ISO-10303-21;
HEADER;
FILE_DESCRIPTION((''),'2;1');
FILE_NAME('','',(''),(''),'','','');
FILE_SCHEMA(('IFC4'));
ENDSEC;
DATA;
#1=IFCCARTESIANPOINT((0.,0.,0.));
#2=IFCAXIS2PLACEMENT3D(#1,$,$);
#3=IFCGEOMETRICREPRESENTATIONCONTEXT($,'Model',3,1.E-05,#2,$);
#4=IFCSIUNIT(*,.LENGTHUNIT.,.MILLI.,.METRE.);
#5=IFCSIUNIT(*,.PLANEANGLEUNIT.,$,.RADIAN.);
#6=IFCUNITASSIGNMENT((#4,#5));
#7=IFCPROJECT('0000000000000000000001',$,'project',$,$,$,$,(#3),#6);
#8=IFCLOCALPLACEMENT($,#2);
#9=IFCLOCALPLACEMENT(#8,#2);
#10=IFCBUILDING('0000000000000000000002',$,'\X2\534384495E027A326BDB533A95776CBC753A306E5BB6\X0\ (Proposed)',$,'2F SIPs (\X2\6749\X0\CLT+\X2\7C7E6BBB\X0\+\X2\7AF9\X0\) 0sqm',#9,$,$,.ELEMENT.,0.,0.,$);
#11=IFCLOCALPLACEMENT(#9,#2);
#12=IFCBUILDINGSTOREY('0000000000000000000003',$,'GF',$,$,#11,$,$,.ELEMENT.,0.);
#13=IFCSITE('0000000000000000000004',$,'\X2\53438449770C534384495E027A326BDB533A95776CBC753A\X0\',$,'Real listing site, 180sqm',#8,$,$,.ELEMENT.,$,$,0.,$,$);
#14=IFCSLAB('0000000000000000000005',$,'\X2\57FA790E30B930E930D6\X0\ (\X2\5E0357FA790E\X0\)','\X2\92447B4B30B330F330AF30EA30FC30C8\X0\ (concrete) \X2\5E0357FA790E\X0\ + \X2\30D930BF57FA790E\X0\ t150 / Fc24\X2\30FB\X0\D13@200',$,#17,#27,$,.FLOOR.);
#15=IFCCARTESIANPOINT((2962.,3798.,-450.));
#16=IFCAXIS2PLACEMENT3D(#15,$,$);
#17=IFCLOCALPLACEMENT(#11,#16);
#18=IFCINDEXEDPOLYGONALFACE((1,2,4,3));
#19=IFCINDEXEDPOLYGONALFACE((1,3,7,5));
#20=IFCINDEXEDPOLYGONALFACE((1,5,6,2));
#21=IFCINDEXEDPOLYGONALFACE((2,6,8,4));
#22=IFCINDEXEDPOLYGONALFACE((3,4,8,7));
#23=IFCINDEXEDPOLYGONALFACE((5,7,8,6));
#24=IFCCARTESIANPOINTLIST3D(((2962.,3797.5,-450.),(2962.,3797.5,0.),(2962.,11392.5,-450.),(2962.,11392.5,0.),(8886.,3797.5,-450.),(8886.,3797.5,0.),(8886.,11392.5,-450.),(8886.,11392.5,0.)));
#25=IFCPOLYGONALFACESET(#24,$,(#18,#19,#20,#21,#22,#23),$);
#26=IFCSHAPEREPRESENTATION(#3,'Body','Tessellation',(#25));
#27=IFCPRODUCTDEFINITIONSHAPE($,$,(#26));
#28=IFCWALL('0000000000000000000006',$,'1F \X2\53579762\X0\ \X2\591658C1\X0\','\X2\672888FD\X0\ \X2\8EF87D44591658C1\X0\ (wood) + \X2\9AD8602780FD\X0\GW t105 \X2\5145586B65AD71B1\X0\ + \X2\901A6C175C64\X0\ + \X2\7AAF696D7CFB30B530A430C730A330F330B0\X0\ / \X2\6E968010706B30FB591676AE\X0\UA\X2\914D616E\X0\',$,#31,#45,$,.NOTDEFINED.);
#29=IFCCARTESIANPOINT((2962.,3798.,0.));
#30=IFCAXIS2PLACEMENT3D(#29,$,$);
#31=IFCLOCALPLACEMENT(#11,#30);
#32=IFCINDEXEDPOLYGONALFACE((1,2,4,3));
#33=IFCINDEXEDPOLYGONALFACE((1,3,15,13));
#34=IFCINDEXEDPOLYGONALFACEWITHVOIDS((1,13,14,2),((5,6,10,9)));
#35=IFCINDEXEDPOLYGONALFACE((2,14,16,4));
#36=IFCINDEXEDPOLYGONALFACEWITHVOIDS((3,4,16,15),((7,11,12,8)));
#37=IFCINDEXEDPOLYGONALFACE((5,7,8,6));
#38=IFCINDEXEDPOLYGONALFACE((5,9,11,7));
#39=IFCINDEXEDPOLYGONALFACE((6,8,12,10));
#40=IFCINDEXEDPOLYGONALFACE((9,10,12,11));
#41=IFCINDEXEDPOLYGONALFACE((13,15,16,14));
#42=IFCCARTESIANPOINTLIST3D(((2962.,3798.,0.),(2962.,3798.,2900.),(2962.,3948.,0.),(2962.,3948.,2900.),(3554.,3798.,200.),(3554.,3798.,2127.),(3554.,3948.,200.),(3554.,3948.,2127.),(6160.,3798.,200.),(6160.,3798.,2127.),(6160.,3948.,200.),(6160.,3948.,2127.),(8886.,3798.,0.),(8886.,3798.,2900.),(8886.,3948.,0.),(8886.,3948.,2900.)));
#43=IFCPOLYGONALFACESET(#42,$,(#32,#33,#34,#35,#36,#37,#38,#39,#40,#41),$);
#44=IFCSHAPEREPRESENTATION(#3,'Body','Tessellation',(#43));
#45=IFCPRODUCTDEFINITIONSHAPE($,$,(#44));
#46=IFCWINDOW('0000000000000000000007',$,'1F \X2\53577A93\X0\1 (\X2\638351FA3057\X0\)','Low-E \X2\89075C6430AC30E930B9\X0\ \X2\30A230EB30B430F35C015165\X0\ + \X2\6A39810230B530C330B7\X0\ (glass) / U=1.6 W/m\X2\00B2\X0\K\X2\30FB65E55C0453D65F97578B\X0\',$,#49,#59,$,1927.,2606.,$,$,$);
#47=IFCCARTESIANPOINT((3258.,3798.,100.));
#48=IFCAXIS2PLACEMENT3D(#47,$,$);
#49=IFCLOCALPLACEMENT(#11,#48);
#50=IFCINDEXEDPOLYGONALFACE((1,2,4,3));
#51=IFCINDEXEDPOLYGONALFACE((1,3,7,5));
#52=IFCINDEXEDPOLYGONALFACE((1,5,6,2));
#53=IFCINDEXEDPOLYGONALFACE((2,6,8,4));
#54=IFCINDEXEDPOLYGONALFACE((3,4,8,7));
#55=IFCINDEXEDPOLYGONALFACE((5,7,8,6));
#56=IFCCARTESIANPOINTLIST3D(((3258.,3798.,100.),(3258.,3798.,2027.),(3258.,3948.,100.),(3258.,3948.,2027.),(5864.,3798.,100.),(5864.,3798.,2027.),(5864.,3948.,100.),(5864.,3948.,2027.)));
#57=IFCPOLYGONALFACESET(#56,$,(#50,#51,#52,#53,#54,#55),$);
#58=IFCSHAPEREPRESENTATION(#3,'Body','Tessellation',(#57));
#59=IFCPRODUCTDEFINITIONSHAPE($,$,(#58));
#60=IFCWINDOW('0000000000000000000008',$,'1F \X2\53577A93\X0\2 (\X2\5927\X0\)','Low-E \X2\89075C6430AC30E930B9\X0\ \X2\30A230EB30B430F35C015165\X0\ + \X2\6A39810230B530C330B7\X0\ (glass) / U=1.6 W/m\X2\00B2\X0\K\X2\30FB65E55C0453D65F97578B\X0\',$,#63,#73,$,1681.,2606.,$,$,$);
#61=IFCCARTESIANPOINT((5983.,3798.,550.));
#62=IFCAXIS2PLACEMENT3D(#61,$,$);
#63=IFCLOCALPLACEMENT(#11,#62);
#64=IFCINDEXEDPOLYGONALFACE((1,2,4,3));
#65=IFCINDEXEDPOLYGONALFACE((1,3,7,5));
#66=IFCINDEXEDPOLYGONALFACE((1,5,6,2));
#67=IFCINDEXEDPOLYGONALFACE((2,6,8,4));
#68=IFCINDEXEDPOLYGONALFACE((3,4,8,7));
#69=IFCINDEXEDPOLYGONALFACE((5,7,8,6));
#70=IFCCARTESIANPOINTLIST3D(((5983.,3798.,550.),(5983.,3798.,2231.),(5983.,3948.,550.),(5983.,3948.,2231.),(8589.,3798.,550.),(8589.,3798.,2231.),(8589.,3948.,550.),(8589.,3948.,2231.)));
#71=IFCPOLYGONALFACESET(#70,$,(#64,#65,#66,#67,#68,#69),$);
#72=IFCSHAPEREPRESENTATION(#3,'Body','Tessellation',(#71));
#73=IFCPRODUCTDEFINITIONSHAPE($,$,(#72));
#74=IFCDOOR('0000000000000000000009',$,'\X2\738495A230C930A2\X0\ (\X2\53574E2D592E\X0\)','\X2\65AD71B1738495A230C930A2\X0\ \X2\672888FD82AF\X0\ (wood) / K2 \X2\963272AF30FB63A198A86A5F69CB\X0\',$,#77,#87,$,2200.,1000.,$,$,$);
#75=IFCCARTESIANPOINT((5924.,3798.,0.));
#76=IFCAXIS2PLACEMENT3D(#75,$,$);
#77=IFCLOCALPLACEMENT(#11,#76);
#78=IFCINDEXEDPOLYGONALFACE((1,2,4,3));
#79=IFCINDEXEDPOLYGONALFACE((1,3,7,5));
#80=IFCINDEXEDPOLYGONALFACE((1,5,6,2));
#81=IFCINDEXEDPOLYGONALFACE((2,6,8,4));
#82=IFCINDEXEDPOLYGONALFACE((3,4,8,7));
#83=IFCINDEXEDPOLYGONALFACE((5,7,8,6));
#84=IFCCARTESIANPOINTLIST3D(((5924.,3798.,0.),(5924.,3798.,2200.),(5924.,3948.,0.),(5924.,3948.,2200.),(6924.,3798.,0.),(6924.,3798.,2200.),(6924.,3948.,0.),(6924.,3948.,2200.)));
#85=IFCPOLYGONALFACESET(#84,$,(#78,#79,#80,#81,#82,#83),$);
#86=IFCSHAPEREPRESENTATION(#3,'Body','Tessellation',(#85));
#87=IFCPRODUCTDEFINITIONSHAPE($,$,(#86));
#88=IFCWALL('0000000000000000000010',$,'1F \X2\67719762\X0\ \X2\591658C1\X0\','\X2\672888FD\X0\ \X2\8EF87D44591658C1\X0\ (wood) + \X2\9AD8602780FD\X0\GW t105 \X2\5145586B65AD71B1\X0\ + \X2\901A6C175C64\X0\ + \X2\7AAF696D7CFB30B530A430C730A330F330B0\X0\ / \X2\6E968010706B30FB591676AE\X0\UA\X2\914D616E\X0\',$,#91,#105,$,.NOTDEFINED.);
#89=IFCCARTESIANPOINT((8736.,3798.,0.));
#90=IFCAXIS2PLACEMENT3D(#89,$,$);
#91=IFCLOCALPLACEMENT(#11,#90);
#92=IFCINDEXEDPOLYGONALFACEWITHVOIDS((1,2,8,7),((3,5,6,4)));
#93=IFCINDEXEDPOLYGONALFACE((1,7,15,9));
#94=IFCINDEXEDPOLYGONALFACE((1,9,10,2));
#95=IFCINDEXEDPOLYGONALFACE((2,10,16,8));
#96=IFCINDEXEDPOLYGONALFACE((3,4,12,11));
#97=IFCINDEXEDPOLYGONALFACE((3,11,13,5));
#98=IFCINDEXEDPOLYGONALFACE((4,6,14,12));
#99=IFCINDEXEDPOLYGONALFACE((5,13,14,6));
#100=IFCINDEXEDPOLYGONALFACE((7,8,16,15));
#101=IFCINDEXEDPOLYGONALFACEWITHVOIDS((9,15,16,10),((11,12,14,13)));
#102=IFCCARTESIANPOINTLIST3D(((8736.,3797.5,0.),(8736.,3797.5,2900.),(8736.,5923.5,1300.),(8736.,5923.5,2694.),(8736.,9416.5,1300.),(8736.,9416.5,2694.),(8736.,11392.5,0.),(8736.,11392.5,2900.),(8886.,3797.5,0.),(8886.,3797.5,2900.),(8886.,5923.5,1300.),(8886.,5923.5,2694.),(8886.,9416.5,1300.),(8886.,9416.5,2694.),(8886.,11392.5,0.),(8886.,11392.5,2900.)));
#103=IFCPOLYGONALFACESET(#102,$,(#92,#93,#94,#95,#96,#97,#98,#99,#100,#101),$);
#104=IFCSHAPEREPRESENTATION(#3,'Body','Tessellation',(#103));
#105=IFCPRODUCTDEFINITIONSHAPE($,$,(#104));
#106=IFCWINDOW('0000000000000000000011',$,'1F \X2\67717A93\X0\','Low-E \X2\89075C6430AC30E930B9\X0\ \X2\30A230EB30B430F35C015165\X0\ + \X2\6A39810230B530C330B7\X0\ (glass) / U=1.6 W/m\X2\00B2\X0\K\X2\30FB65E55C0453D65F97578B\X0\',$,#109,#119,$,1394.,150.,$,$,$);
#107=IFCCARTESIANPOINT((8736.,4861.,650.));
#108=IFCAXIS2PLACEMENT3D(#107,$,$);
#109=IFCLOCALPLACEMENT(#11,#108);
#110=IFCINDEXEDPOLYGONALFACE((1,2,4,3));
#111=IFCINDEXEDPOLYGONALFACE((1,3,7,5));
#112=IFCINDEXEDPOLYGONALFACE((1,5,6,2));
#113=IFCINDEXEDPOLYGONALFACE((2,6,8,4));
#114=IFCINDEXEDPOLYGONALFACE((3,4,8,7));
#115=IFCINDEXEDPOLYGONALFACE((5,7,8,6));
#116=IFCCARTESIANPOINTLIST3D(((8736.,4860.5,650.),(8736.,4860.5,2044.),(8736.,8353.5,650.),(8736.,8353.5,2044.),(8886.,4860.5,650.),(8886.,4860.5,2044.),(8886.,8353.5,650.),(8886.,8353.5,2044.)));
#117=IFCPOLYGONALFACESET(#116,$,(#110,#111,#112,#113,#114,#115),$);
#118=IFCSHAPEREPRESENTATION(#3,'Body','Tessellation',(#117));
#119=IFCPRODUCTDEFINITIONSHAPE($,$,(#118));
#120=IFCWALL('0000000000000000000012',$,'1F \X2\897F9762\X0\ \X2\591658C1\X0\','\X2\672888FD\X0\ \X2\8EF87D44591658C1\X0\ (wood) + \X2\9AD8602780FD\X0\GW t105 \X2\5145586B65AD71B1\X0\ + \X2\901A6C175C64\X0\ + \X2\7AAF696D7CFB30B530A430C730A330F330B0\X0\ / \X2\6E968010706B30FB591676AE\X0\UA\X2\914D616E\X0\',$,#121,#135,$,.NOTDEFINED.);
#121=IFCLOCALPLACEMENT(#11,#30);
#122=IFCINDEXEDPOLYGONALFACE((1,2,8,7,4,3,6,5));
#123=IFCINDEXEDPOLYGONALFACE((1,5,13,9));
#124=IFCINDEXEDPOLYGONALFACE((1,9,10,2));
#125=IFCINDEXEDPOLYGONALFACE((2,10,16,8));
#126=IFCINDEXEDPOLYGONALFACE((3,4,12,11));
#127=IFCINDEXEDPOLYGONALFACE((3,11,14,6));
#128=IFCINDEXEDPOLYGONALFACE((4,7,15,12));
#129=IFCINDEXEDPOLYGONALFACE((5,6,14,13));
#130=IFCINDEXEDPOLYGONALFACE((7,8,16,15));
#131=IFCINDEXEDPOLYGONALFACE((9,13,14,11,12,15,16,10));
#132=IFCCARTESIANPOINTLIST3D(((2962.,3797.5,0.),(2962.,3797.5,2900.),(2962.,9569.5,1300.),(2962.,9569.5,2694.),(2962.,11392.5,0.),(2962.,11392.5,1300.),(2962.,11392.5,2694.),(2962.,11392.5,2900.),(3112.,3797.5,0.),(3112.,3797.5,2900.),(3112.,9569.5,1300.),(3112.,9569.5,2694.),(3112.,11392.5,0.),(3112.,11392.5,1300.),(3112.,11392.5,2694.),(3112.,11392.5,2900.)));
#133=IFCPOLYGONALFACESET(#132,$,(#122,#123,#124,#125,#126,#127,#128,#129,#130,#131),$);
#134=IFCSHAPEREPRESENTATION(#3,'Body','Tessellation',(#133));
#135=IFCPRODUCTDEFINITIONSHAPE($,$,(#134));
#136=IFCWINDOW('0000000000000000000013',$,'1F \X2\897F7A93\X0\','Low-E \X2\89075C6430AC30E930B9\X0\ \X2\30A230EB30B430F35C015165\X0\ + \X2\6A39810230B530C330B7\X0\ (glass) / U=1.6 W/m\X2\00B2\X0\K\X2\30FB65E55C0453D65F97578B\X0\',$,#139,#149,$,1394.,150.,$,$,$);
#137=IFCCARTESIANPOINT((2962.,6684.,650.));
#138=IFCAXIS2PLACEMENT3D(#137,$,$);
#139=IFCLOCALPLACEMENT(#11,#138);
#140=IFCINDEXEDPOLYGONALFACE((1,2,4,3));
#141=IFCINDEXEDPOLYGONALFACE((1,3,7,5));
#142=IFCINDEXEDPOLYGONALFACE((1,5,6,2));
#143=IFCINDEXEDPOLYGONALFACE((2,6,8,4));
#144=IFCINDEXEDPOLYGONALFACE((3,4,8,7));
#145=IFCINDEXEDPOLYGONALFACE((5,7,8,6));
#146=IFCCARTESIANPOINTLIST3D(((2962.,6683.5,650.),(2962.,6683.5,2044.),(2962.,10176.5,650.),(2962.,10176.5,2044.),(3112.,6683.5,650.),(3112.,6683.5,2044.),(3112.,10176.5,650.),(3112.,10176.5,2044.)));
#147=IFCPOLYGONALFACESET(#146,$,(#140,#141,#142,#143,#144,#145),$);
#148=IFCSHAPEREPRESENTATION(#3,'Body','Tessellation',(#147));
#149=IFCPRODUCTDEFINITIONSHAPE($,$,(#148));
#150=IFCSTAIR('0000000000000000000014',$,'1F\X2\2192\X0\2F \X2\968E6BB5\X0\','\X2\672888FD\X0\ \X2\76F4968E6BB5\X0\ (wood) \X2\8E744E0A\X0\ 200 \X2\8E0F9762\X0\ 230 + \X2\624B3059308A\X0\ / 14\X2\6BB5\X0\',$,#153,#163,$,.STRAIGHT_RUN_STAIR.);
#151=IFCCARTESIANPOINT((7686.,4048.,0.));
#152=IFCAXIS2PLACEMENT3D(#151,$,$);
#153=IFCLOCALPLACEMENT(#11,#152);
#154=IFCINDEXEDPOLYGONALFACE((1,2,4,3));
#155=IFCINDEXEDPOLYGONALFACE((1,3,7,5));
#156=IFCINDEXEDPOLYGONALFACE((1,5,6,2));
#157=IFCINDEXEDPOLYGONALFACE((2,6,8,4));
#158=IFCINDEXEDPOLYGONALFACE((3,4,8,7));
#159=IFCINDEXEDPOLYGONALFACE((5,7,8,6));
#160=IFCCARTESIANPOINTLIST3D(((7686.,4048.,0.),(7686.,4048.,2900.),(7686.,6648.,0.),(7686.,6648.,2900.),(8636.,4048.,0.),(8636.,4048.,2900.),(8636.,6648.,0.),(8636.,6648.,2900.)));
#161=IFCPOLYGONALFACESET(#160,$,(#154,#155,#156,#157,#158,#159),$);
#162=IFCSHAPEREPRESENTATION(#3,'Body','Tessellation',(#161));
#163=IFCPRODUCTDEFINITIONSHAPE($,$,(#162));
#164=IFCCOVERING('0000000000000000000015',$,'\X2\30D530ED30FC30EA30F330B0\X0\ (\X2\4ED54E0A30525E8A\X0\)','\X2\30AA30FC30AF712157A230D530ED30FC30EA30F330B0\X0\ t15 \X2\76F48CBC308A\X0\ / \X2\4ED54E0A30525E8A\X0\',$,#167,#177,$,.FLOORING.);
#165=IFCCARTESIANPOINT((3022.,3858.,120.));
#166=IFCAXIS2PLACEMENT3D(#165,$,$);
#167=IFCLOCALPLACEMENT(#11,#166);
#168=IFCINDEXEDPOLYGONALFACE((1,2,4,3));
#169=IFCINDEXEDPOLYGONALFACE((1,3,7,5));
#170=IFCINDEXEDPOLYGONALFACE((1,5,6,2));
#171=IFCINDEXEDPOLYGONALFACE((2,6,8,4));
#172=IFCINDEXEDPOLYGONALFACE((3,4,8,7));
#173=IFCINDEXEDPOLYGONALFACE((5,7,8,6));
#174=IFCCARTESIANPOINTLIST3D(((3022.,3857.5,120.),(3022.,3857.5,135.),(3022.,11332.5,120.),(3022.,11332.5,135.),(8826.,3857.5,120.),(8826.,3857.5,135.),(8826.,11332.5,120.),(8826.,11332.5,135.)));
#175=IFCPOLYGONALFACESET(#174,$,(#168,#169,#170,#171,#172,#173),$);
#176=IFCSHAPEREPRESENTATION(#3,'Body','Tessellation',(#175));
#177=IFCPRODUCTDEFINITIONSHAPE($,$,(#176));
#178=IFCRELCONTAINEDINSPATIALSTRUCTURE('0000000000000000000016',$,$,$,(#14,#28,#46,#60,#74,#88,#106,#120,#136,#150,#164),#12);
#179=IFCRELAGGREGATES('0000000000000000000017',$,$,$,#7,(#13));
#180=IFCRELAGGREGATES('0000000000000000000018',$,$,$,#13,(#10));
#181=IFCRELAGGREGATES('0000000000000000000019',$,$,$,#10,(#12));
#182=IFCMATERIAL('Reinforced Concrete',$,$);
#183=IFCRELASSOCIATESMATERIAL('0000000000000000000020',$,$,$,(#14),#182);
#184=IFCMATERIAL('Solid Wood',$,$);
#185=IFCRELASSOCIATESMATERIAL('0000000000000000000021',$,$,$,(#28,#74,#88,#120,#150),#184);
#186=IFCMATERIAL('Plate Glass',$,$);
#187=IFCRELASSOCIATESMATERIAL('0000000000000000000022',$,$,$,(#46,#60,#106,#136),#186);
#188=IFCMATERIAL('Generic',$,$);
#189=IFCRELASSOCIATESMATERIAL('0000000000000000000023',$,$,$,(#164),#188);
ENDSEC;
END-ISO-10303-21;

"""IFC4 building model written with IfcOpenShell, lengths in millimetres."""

from ifc_helpers import new_model, si_unit, frame, frame_2d, origin, place, context, project, spatial, rectangle, extrude, material, element, fill, save


model = new_model("IFC4")

# Units and contexts
model_context = context("Model", 3, precision=1e-05, world=origin())
ifc_project = project(units=[si_unit("LENGTHUNIT", "METRE", prefix="MILLI"), si_unit("PLANEANGLEUNIT", "RADIAN")], contexts=[model_context])

# Site, building, storey
site_placement = place(None, origin())
site = spatial("IfcSite", under=ifc_project, at=site_placement, Name="千葉県千葉市稲毛区長沼町", ObjectType="Real listing site, 180sqm", CompositionType="ELEMENT", RefElevation=0.0)
building_placement = place(site_placement, origin())
building = spatial("IfcBuilding", under=site, at=building_placement, Name="千葉市稲毛区長沼町の家 (Proposed)", ObjectType="2F SIPs (杉CLT+籾殻+竹) 0sqm", CompositionType="ELEMENT", ElevationOfRefHeight=0.0, ElevationOfTerrain=0.0)
storey_placement = place(building_placement, origin())
storey = spatial("IfcBuildingStorey", under=building, at=storey_placement, Name="GF", CompositionType="ELEMENT", Elevation=0.0)

# Slab
ifc_material_1 = material(Name="Reinforced Concrete")
slab_1_placement = place(storey_placement, frame((2962.0, 3798.0, -450.0)))
element("IfcSlab", 1, at=slab_1_placement, inside=storey, material=ifc_material_1, Name="基礎スラブ (布基礎)", Description="鉄筋コンクリート (concrete) 布基礎 + ベタ基礎 t150 / Fc24・D13@200", PredefinedType="FLOOR", context=model_context, shape_type="SweptSolid", body=[
    extrude(rectangle(XDim=5924.0, YDim=7595.0, at=frame_2d((2962.0, 3797.0))), frame((2962.0, 3798.0, -450.0)), (0.0, 0.0, 1.0), 450.0),
])
ifc_material_2 = material(Name="Solid Wood")

# Wall, openings, windows, door
wall_1_placement = place(storey_placement, frame((2962.0, 3798.0, 0.0)))
wall_1 = element("IfcWall", 2, at=wall_1_placement, inside=storey, material=ifc_material_2, Name="1F 南面 外壁", Description="木製 軸組外壁 (wood) + 高性能GW t105 充填断熱 + 通気層 + 窯業系サイディング / 準耐火・外皮UA配慮", PredefinedType="NOTDEFINED", context=model_context, shape_type="SweptSolid", body=[
    extrude(rectangle(XDim=5924.0, YDim=150.0, at=frame_2d((2962.0, 75.0))), frame((2962.0, 3798.0, 0.0)), (0.0, 0.0, 1.0), 2900.0),
])
opening_1_placement = place(storey_placement, frame((3258.0, 3798.0, 100.0)))
opening_1 = element("IfcOpeningElement", 3, at=opening_1_placement, cuts=wall_1, PredefinedType="NOTDEFINED", context=model_context, shape_type="SweptSolid", body=[
    extrude(rectangle(XDim=2606.0, YDim=150.0, at=frame_2d((1303.0, 75.0))), frame((3258.0, 3798.0, 100.0)), (0.0, 0.0, 1.0), 1927.0),
])
opening_2_placement = place(storey_placement, frame((5983.0, 3798.0, 550.0)))
opening_2 = element("IfcOpeningElement", 4, at=opening_2_placement, cuts=wall_1, PredefinedType="NOTDEFINED", context=model_context, shape_type="SweptSolid", body=[
    extrude(rectangle(XDim=2606.0, YDim=150.0, at=frame_2d((1303.0, 75.0))), frame((5983.0, 3798.0, 550.0)), (0.0, 0.0, 1.0), 1681.0),
])
opening_3_placement = place(storey_placement, frame((5924.0, 3798.0, 0.0)))
opening_3 = element("IfcOpeningElement", 5, at=opening_3_placement, cuts=wall_1, PredefinedType="NOTDEFINED", context=model_context, shape_type="SweptSolid", body=[
    extrude(rectangle(XDim=1000.0, YDim=150.0, at=frame_2d((500.0, 75.0))), frame((5924.0, 3798.0, 0.0)), (0.0, 0.0, 1.0), 2200.0),
])
ifc_material_3 = material(Name="Plate Glass")
window_1_placement = place(storey_placement, frame((3258.0, 3798.0, 100.0)))
window_1 = element("IfcWindow", 6, at=window_1_placement, inside=storey, material=ifc_material_3, Name="1F 南窓1 (掃出し)", Description="Low-E 複層ガラス アルゴン封入 + 樹脂サッシ (glass) / U=1.6 W/m²K・日射取得型", OverallHeight=1927.0, OverallWidth=2606.0, context=model_context, shape_type="SweptSolid", body=[
    extrude(rectangle(XDim=2606.0, YDim=150.0, at=frame_2d((1303.0, 75.0))), frame((3258.0, 3798.0, 100.0)), (0.0, 0.0, 1.0), 1927.0),
])
fill(opening_1, window_1)
window_2_placement = place(storey_placement, frame((5983.0, 3798.0, 550.0)))
window_2 = element("IfcWindow", 7, at=window_2_placement, inside=storey, material=ifc_material_3, Name="1F 南窓2 (大)", Description="Low-E 複層ガラス アルゴン封入 + 樹脂サッシ (glass) / U=1.6 W/m²K・日射取得型", OverallHeight=1681.0, OverallWidth=2606.0, context=model_context, shape_type="SweptSolid", body=[
    extrude(rectangle(XDim=2606.0, YDim=150.0, at=frame_2d((1303.0, 75.0))), frame((5983.0, 3798.0, 550.0)), (0.0, 0.0, 1.0), 1681.0),
])
fill(opening_2, window_2)
door_placement = place(storey_placement, frame((5924.0, 3798.0, 0.0)))
door = element("IfcDoor", 8, at=door_placement, inside=storey, material=ifc_material_2, Name="玄関ドア (南中央)", Description="断熱玄関ドア 木製芯 (wood) / K2 防犯・採風機構", OverallHeight=2200.0, OverallWidth=1000.0, context=model_context, shape_type="SweptSolid", body=[
    extrude(rectangle(XDim=1000.0, YDim=150.0, at=frame_2d((500.0, 75.0))), frame((5924.0, 3798.0, 0.0)), (0.0, 0.0, 1.0), 2200.0),
])
fill(opening_3, door)

# Walls, openings, windows
wall_2_placement = place(storey_placement, frame((8736.0, 3798.0, 0.0)))
wall_2 = element("IfcWall", 9, at=wall_2_placement, inside=storey, material=ifc_material_2, Name="1F 東面 外壁", Description="木製 軸組外壁 (wood) + 高性能GW t105 充填断熱 + 通気層 + 窯業系サイディング / 準耐火・外皮UA配慮", PredefinedType="NOTDEFINED", context=model_context, shape_type="SweptSolid", body=[
    extrude(rectangle(XDim=150.0, YDim=7595.0, at=frame_2d((75.0, 3797.0))), frame((8736.0, 3798.0, 0.0)), (0.0, 0.0, 1.0), 2900.0),
])
opening_4_placement = place(storey_placement, frame((8736.0, 4861.0, 650.0)))
opening_4 = element("IfcOpeningElement", 10, at=opening_4_placement, cuts=wall_2, PredefinedType="NOTDEFINED", context=model_context, shape_type="SweptSolid", body=[
    extrude(rectangle(XDim=150.0, YDim=3493.0, at=frame_2d((75.0, 1746.0))), frame((8736.0, 4861.0, 650.0)), (0.0, 0.0, 1.0), 1394.0),
])
window_3_placement = place(storey_placement, frame((8736.0, 4861.0, 650.0)))
window_3 = element("IfcWindow", 11, at=window_3_placement, inside=storey, material=ifc_material_3, Name="1F 東窓", Description="Low-E 複層ガラス アルゴン封入 + 樹脂サッシ (glass) / U=1.6 W/m²K・日射取得型", OverallHeight=1394.0, OverallWidth=150.0, context=model_context, shape_type="SweptSolid", body=[
    extrude(rectangle(XDim=150.0, YDim=3493.0, at=frame_2d((75.0, 1746.0))), frame((8736.0, 4861.0, 650.0)), (0.0, 0.0, 1.0), 1394.0),
])
fill(opening_4, window_3)
wall_3_placement = place(storey_placement, frame((2962.0, 3798.0, 0.0)))
wall_3 = element("IfcWall", 12, at=wall_3_placement, inside=storey, material=ifc_material_2, Name="1F 西面 外壁", Description="木製 軸組外壁 (wood) + 高性能GW t105 充填断熱 + 通気層 + 窯業系サイディング / 準耐火・外皮UA配慮", PredefinedType="NOTDEFINED", context=model_context, shape_type="SweptSolid", body=[
    extrude(rectangle(XDim=150.0, YDim=7595.0, at=frame_2d((75.0, 3797.0))), frame((2962.0, 3798.0, 0.0)), (0.0, 0.0, 1.0), 2900.0),
])
opening_5_placement = place(storey_placement, frame((2962.0, 6684.0, 650.0)))
opening_5 = element("IfcOpeningElement", 13, at=opening_5_placement, cuts=wall_3, PredefinedType="NOTDEFINED", context=model_context, shape_type="SweptSolid", body=[
    extrude(rectangle(XDim=150.0, YDim=3493.0, at=frame_2d((75.0, 1746.0))), frame((2962.0, 6684.0, 650.0)), (0.0, 0.0, 1.0), 1394.0),
])
window_4_placement = place(storey_placement, frame((2962.0, 6684.0, 650.0)))
window_4 = element("IfcWindow", 14, at=window_4_placement, inside=storey, material=ifc_material_3, Name="1F 西窓", Description="Low-E 複層ガラス アルゴン封入 + 樹脂サッシ (glass) / U=1.6 W/m²K・日射取得型", OverallHeight=1394.0, OverallWidth=150.0, context=model_context, shape_type="SweptSolid", body=[
    extrude(rectangle(XDim=150.0, YDim=3493.0, at=frame_2d((75.0, 1746.0))), frame((2962.0, 6684.0, 650.0)), (0.0, 0.0, 1.0), 1394.0),
])
fill(opening_5, window_4)

# Stair
stair_placement = place(storey_placement, frame((7686.0, 4048.0, 0.0)))
element("IfcStair", 15, at=stair_placement, inside=storey, material=ifc_material_2, Name="1F→2F 階段", Description="木製 直階段 (wood) 蹴上 200 踏面 230 + 手すり / 14段", PredefinedType="STRAIGHT_RUN_STAIR", context=model_context, shape_type="SweptSolid", body=[
    extrude(rectangle(XDim=950.0, YDim=2600.0, at=frame_2d((475.0, 1300.0))), frame((7686.0, 4048.0, 0.0)), (0.0, 0.0, 1.0), 2900.0),
])

# Covering
ifc_material_4 = material(Name="Generic")
covering_placement = place(storey_placement, frame((3022.0, 3858.0, 120.0)))
element("IfcCovering", 16, at=covering_placement, inside=storey, material=ifc_material_4, Name="フローリング (仕上げ床)", Description="オーク無垢フローリング t15 直貼り / 仕上げ床", PredefinedType="FLOORING", context=model_context, shape_type="SweptSolid", body=[
    extrude(rectangle(XDim=5804.0, YDim=7475.0, at=frame_2d((2902.0, 3737.0))), frame((3022.0, 3858.0, 120.0)), (0.0, 0.0, 1.0), 15.0),
])

save(model, "model.ifc")
